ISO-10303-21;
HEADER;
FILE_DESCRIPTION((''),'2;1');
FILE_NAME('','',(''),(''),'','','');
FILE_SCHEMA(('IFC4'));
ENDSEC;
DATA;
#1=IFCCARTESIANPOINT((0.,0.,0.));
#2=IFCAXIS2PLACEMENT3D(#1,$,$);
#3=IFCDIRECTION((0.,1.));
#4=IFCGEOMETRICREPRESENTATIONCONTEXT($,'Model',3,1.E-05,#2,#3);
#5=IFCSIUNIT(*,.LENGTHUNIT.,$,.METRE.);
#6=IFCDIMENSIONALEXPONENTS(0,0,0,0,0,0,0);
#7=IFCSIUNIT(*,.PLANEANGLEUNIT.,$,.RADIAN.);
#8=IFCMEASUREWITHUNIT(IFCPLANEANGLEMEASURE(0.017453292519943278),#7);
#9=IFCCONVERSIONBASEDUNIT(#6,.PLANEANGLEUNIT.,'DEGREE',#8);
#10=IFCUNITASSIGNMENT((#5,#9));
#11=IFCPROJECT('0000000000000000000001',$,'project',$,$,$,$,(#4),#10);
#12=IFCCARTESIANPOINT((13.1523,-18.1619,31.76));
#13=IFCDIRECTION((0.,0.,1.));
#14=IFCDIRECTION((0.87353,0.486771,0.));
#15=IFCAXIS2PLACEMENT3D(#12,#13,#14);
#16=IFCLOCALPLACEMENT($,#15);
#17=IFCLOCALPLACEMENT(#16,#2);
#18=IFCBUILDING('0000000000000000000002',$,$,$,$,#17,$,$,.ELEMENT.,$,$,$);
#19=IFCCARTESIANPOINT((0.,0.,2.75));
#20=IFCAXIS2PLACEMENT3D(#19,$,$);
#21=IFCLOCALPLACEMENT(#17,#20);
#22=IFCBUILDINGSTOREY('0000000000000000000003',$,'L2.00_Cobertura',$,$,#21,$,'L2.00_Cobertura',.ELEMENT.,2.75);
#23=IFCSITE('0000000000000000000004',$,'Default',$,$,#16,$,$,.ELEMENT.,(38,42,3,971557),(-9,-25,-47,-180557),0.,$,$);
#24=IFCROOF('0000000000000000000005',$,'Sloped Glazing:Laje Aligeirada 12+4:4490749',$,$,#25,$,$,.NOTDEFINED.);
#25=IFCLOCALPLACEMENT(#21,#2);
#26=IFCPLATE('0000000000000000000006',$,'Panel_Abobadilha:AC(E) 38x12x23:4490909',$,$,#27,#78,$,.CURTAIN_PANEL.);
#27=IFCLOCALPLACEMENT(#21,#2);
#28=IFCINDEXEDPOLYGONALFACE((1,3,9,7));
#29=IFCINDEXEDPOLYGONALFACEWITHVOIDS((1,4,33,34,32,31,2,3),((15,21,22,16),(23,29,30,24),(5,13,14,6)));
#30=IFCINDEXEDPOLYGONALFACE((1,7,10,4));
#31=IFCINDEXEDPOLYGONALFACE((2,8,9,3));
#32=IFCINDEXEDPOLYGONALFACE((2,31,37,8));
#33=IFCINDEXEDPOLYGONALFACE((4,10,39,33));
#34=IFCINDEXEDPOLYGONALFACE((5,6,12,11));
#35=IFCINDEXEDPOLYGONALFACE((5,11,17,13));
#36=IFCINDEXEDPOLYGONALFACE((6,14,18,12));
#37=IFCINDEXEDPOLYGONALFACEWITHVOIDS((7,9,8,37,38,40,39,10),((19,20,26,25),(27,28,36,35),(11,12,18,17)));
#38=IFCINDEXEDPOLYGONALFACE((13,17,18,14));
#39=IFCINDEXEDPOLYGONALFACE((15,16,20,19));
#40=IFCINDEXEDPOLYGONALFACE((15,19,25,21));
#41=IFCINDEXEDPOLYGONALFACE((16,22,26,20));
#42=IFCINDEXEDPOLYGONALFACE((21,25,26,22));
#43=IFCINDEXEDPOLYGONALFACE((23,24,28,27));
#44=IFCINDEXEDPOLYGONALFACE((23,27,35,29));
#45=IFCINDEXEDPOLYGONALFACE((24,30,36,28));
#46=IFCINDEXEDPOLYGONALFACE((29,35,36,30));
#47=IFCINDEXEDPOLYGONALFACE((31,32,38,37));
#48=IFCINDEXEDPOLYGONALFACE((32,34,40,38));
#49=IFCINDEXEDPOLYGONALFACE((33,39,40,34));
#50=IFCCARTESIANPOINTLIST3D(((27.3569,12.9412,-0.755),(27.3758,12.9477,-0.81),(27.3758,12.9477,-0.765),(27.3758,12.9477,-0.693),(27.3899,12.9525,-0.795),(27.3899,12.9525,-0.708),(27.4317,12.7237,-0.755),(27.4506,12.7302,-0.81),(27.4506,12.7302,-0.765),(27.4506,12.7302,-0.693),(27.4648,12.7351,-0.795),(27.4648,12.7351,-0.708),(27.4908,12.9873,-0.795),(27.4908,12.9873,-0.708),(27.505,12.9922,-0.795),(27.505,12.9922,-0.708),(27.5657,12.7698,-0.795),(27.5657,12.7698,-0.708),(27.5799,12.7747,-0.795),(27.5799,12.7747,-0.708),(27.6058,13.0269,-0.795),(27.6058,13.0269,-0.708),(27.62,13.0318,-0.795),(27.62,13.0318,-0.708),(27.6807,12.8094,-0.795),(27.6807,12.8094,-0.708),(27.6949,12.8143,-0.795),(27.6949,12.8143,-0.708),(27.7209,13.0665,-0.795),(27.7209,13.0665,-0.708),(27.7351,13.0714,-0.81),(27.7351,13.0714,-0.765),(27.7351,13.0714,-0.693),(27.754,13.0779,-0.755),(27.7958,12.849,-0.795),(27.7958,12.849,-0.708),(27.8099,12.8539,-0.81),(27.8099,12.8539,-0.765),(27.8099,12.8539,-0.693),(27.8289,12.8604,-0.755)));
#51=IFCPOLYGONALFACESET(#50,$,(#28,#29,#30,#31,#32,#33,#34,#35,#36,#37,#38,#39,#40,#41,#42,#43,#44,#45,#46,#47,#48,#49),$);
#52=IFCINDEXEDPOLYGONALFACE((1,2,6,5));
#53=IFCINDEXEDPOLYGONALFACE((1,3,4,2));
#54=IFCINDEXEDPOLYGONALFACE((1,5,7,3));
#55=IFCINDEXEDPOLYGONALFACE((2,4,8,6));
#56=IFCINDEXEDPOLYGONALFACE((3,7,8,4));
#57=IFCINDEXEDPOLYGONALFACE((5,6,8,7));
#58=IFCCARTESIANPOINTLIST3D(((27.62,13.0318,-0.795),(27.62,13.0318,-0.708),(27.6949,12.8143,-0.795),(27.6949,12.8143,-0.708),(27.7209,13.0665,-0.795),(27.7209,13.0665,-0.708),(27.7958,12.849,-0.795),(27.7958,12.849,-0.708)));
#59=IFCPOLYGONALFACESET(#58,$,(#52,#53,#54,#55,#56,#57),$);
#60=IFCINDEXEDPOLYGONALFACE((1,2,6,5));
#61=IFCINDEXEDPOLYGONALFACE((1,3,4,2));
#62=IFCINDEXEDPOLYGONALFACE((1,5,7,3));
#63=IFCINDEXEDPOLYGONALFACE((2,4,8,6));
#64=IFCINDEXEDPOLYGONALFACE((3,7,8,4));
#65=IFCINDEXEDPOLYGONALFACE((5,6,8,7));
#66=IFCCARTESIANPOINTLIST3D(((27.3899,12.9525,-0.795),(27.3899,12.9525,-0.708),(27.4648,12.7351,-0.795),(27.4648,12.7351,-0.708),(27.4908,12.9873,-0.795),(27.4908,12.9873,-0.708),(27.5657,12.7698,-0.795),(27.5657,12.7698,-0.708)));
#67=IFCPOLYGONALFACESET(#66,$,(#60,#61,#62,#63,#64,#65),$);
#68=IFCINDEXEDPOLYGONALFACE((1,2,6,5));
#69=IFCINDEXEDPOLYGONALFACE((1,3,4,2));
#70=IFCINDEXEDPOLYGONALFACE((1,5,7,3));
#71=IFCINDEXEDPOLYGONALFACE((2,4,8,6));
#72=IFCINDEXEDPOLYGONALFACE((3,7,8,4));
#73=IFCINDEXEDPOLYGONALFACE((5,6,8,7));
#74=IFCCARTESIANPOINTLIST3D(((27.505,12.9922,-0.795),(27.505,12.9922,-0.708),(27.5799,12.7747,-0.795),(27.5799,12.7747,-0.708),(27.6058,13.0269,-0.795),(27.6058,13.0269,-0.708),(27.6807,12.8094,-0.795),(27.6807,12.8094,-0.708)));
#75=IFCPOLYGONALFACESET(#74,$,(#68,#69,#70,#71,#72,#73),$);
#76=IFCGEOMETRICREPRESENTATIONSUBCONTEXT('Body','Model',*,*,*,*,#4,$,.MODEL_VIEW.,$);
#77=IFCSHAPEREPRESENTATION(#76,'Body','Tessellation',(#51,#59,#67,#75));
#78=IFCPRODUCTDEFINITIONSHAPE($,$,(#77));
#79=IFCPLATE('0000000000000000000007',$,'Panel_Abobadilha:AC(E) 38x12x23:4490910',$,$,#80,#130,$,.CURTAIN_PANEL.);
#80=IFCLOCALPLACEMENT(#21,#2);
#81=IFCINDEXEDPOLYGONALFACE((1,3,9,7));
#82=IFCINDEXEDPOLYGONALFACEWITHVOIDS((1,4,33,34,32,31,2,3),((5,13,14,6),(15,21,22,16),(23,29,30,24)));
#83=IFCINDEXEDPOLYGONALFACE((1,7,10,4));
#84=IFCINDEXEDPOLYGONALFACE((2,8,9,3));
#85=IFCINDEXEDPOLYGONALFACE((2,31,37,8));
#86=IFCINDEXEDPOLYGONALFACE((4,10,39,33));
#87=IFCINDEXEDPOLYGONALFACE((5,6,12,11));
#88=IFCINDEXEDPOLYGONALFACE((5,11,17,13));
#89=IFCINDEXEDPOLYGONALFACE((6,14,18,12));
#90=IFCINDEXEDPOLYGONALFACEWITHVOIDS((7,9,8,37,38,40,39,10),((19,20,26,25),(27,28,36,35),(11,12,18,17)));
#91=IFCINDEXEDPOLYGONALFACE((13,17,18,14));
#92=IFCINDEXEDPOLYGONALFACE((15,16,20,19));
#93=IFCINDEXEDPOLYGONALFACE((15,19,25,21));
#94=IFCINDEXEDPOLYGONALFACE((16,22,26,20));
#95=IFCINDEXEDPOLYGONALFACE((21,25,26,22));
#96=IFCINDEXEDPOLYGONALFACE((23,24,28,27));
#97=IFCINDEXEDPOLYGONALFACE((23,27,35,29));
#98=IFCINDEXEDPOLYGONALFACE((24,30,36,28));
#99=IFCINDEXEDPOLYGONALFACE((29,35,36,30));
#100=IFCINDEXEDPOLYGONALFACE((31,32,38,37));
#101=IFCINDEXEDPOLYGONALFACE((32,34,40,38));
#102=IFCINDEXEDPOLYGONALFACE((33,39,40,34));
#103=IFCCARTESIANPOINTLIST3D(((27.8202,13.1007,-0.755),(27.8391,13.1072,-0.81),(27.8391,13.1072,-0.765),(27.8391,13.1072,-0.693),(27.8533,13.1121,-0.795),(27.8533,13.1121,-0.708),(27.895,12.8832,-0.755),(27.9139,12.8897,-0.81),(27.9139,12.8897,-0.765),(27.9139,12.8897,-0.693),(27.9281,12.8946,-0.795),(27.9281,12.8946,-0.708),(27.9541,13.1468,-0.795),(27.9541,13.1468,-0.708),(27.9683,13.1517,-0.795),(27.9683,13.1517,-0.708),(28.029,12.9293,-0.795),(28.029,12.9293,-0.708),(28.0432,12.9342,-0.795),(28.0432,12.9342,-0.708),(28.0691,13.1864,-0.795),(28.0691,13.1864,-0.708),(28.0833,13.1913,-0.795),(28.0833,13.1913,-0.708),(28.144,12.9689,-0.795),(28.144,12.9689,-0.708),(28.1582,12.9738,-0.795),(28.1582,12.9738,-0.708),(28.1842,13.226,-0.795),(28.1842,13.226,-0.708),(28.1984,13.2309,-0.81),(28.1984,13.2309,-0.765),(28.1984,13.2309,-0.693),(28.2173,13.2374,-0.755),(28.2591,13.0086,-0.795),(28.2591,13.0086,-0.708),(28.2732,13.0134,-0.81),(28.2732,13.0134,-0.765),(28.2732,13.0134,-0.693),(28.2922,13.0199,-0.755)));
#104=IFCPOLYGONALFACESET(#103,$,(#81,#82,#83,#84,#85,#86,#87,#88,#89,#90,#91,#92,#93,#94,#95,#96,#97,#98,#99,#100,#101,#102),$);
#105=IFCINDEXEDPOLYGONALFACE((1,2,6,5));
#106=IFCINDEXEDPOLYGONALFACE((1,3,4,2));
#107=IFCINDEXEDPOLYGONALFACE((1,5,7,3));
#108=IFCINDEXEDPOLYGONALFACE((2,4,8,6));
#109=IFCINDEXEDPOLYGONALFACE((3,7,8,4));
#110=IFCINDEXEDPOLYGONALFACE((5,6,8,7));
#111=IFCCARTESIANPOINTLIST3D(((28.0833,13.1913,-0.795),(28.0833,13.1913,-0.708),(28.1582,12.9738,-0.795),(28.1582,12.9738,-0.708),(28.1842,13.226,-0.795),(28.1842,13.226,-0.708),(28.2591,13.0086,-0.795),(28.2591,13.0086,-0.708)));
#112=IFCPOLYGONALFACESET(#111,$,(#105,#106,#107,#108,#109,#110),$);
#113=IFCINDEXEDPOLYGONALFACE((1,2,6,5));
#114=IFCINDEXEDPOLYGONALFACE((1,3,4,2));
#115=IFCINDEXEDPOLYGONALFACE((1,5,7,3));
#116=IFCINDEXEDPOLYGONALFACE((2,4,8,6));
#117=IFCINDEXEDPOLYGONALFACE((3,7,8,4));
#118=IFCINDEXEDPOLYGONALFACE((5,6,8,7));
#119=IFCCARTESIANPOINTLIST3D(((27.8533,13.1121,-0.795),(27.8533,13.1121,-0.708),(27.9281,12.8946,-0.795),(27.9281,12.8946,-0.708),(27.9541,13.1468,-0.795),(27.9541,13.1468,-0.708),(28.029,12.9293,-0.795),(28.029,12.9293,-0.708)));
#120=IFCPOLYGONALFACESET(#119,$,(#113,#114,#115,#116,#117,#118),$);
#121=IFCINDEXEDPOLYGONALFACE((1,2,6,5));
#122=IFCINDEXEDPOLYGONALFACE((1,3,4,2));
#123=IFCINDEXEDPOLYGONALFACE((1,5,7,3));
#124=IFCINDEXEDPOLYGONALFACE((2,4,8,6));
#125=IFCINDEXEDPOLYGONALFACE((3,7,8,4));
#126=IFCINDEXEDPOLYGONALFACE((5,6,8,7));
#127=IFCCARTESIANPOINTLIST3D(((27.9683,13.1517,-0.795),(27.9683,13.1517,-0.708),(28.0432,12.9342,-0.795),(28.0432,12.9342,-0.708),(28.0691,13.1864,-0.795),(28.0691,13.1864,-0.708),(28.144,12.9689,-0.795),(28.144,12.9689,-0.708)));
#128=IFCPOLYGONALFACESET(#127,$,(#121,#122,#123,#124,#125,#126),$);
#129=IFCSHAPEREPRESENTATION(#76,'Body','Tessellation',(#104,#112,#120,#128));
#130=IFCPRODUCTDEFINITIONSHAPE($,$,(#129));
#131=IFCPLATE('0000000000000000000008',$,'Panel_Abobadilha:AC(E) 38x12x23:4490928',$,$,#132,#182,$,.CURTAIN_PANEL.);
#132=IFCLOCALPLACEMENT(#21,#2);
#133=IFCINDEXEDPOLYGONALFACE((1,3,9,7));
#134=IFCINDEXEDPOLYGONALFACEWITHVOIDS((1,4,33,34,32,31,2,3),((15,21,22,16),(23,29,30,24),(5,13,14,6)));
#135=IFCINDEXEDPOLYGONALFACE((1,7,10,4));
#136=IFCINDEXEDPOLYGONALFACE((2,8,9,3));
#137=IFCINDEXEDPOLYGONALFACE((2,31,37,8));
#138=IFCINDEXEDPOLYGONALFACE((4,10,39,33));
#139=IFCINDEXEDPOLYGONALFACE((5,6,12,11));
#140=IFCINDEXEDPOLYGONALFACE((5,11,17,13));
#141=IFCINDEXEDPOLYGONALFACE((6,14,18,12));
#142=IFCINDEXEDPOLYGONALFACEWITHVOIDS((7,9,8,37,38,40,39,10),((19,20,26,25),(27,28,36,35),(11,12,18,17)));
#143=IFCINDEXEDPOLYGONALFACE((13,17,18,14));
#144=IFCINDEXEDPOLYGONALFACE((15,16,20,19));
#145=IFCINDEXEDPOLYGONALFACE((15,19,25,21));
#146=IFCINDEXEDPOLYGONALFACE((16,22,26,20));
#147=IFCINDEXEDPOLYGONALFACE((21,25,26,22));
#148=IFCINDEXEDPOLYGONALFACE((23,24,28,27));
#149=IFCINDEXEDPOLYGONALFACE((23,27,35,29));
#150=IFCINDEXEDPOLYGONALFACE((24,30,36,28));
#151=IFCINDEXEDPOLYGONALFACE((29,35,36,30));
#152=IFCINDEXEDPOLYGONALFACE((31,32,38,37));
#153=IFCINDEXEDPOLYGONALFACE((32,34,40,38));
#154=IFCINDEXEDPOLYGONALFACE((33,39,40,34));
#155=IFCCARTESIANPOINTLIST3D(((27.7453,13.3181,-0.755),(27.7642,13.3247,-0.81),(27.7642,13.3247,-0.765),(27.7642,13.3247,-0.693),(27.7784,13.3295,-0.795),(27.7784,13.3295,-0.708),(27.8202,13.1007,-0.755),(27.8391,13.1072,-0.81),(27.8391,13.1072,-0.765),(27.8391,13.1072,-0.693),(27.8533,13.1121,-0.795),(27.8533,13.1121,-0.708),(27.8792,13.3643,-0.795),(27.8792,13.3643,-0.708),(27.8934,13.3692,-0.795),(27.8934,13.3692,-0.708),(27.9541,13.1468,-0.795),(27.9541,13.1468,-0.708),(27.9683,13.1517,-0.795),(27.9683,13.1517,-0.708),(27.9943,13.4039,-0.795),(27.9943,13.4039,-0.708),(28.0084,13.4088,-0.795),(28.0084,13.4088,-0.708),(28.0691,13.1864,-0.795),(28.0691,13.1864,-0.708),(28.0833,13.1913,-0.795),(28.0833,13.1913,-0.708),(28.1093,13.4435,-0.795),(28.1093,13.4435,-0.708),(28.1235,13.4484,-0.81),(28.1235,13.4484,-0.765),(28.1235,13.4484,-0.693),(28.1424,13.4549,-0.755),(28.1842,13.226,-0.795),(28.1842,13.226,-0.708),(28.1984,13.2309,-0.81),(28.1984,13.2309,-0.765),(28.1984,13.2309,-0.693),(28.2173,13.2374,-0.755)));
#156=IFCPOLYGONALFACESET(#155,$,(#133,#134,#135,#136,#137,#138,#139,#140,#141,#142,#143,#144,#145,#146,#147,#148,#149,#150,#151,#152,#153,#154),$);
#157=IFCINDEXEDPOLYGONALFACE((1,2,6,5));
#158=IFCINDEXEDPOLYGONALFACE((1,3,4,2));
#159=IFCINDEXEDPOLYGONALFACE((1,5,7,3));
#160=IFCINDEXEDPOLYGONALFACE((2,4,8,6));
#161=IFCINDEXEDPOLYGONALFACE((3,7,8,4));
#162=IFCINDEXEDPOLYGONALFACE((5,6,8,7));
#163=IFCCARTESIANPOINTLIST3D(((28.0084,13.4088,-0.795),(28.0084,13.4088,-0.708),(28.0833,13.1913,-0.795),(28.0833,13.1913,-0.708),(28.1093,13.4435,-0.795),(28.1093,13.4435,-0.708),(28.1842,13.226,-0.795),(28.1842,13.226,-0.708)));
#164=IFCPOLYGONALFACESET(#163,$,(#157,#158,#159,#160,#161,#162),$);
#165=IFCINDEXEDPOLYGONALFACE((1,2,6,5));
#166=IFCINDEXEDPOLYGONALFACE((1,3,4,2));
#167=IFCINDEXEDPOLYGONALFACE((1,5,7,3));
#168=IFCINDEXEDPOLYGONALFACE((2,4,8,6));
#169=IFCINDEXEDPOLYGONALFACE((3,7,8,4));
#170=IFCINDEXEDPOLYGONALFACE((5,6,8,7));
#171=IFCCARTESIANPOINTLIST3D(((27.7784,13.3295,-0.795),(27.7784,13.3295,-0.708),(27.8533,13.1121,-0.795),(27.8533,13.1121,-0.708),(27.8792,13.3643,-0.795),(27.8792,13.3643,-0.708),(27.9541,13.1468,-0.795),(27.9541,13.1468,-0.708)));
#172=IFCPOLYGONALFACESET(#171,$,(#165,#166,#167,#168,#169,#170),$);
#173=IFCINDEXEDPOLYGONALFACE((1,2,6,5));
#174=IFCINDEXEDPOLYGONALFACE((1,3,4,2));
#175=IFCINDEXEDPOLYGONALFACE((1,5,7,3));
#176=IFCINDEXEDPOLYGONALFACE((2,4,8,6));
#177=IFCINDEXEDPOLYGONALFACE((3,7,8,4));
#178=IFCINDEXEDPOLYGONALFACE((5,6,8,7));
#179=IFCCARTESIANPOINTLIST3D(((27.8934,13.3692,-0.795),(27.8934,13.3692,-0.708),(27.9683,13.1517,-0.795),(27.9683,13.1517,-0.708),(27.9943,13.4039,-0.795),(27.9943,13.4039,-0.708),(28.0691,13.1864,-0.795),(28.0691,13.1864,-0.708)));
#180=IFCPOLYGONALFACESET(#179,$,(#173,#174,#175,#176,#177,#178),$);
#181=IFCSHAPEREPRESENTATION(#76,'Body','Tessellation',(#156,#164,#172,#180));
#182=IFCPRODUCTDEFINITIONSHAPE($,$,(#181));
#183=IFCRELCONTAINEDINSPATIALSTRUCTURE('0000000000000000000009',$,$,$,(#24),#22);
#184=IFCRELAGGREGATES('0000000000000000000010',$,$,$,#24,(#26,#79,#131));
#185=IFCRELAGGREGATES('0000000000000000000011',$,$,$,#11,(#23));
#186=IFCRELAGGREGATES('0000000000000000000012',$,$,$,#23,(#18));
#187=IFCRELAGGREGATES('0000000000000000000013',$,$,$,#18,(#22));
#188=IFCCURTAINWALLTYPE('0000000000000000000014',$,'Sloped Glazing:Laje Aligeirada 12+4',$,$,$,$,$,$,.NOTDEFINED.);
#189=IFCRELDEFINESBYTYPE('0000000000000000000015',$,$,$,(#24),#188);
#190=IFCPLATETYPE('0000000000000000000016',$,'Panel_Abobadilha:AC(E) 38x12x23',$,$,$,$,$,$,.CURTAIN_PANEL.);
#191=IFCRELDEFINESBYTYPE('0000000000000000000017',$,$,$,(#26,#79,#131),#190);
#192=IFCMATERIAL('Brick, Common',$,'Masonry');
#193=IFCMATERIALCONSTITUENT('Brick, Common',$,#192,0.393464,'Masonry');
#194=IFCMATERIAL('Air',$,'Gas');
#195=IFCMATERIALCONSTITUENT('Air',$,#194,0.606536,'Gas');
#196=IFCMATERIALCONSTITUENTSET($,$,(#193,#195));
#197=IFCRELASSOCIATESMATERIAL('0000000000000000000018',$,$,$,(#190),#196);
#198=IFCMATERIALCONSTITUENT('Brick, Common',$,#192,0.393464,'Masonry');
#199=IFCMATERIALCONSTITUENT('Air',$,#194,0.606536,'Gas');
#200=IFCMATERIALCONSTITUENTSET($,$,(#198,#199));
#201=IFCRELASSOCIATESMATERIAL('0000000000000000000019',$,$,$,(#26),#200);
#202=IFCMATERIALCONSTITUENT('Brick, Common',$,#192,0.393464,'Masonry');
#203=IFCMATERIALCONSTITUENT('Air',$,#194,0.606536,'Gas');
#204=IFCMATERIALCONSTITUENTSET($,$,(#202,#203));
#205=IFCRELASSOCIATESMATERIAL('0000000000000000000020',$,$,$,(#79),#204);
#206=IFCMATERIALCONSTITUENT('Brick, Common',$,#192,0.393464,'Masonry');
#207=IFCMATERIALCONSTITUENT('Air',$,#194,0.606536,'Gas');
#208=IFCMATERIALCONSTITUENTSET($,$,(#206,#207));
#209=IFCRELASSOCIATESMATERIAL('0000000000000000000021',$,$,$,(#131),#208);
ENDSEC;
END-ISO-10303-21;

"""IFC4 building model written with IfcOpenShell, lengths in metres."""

from ifc_helpers import new_model, entity, si_unit, converted_unit, direction, frame, origin, place, context, subcontext, project, spatial, indexed_curve, outline, extrude, source, transform, mapped, material, constituent, constituent_set, type_object, type_shapes, element, aggregate, save


model = new_model("IFC4")

# Units and contexts
model_context = context("Model", 3, precision=1e-05, world=origin(), true_north=direction((0.0, 1.0)))
body_context = subcontext(model_context, "Body", "Model", "MODEL_VIEW")
ifc_project = project(units=[si_unit("LENGTHUNIT", "METRE"), converted_unit("PLANEANGLEUNIT", "DEGREE", entity("IfcPlaneAngleMeasure", 0.017453292519943278), si_unit("PLANEANGLEUNIT", "RADIAN"), dimensions=[0, 0, 0, 0, 0, 0, 0])], contexts=[model_context])

# Site, building, storey
site_placement = place(None, frame((13.1523, -18.1619, 31.76), z_axis=(0.0, 0.0, 1.0), x_axis=(0.87353, 0.486771, 0.0)))
site = spatial("IfcSite", under=ifc_project, at=site_placement, Name="Default", CompositionType="ELEMENT", RefLatitude=(38, 42, 3, 971557), RefLongitude=(-9, -25, -47, -180557), RefElevation=0.0)
building_placement = place(site_placement, origin())
building = spatial("IfcBuilding", under=site, at=building_placement, CompositionType="ELEMENT")
storey_placement = place(building_placement, frame((0.0, 0.0, 2.75)))
storey = spatial("IfcBuildingStorey", under=building, at=storey_placement, Name="L2.00_Cobertura", LongName="L2.00_Cobertura", CompositionType="ELEMENT", Elevation=2.75)

# Roof, plates
curtain_wall_type = type_object("IfcCurtainWallType", Name="Sloped Glazing:Laje Aligeirada 12+4", PredefinedType="NOTDEFINED")
roof_placement = place(storey_placement, frame((0.0, 0.0, -2.75)))
roof = element("IfcRoof", 1, at=roof_placement, inside=storey, type_object=curtain_wall_type, Name="Sloped Glazing:Laje Aligeirada 12+4:4490749", PredefinedType="NOTDEFINED")
ifc_material_1 = material(Name="Brick, Common", Category="Masonry")
ifc_material_2 = material(Name="Air", Category="Gas")
ifc_constituent_1 = constituent(ifc_material_1, Name="Brick, Common", Category="Masonry", fraction=0.393464)
ifc_constituent_2 = constituent(ifc_material_2, Name="Air", Category="Gas", fraction=0.606536)
ifc_constituent_set_1 = constituent_set(constituents=[ifc_constituent_1, ifc_constituent_2])
plate_type_1 = type_object("IfcPlateType", Name="Panel_Abobadilha:AC(E) 38x12x23", PredefinedType="CURTAIN_PANEL", material=ifc_constituent_set_1)
shared_shape_1 = source(origin(), body_context, "Body", "SweptSolid", [
    extrude(outline(indexed_curve([(-0.19, -0.0543), (0.19, -0.0543), (0.19, -0.0093), (0.21, 0.0007), (0.19, 0.0628), (-0.19, 0.0628), (-0.21, 0.0007), (-0.19, -0.0093), (-0.19, -0.0543)], self_intersect=False), holes=[indexed_curve([(-0.0683, 0.0477), (-0.0683, -0.0393), (-0.175, -0.0393), (-0.175, 0.0477), (-0.0683, 0.0477)], self_intersect=False), indexed_curve([(0.0533, 0.0477), (0.0533, -0.0393), (-0.0533, -0.0393), (-0.0533, 0.0477), (0.0533, 0.0477)], self_intersect=False), indexed_curve([(0.175, 0.0477), (0.175, -0.0393), (0.0683, -0.0393), (0.0683, 0.0477), (0.175, 0.0477)], self_intersect=False)]), frame((0.0, 0.0543, 0.0)), (0.0, 0.0, 1.0), 0.23),
    extrude(outline(indexed_curve([(-0.0533, -0.0435), (0.0533, -0.0435), (0.0533, 0.0435), (-0.0533, 0.0435), (-0.0533, -0.0435)], self_intersect=False)), frame((0.1217, 0.0585, 0.0), z_axis=(0.0, 0.0, 1.0), x_axis=(-1.0, 0.0, 0.0)), (0.0, 0.0, 1.0), 0.23),
    extrude(outline(indexed_curve([(-0.0533, -0.0435), (0.0533, -0.0435), (0.0533, 0.0435), (-0.0533, 0.0435), (-0.0533, -0.0435)], self_intersect=False)), frame((-0.1217, 0.0585, 0.0), z_axis=(0.0, 0.0, 1.0), x_axis=(-1.0, 0.0, 0.0)), (0.0, 0.0, 1.0), 0.23),
    extrude(outline(indexed_curve([(-0.0533, -0.0435), (0.0533, -0.0435), (0.0533, 0.0435), (-0.0533, 0.0435), (-0.0533, -0.0435)], self_intersect=False)), frame((0.0, 0.0585, 0.0), z_axis=(0.0, 0.0, 1.0), x_axis=(-1.0, 0.0, 0.0)), (0.0, 0.0, 1.0), 0.23),
])
type_shapes(plate_type_1, [shared_shape_1])
ifc_constituent_3 = constituent(ifc_material_1, Name="Brick, Common", Category="Masonry", fraction=0.393464)
ifc_constituent_4 = constituent(ifc_material_2, Name="Air", Category="Gas", fraction=0.606536)
ifc_constituent_set_2 = constituent_set(constituents=[ifc_constituent_3, ifc_constituent_4])
plate_1_placement = place(roof_placement, frame((27.5554, 13.0095, 1.94), z_axis=(0.325568, -0.945519, 0.0), x_axis=(0.945519, 0.325568, 0.0)))
plate_1 = element("IfcPlate", 2, at=plate_1_placement, type_object=plate_type_1, material=ifc_constituent_set_2, Name="Panel_Abobadilha:AC(E) 38x12x23:4490909", PredefinedType="CURTAIN_PANEL", context=body_context, shape_type="MappedRepresentation", body=[
    mapped(shared_shape_1, transform((0.0, 0.0, 0.0), scale=1.0)),
])
ifc_constituent_5 = constituent(ifc_material_1, Name="Brick, Common", Category="Masonry", fraction=0.393464)
ifc_constituent_6 = constituent(ifc_material_2, Name="Air", Category="Gas", fraction=0.606536)
ifc_constituent_set_3 = constituent_set(constituents=[ifc_constituent_5, ifc_constituent_6])
plate_2_placement = place(roof_placement, frame((28.0187, 13.169, 1.94), z_axis=(0.325568, -0.945519, 0.0), x_axis=(0.945519, 0.325568, 0.0)))
plate_2 = element("IfcPlate", 3, at=plate_2_placement, type_object=plate_type_1, material=ifc_constituent_set_3, Name="Panel_Abobadilha:AC(E) 38x12x23:4490910", PredefinedType="CURTAIN_PANEL", context=body_context, shape_type="MappedRepresentation", body=[
    mapped(shared_shape_1, transform((0.0, 0.0, 0.0), scale=1.0)),
])
ifc_constituent_7 = constituent(ifc_material_1, Name="Brick, Common", Category="Masonry", fraction=0.393464)
ifc_constituent_8 = constituent(ifc_material_2, Name="Air", Category="Gas", fraction=0.606536)
ifc_constituent_set_4 = constituent_set(constituents=[ifc_constituent_7, ifc_constituent_8])
plate_3_placement = place(roof_placement, frame((27.9438, 13.3865, 1.94), z_axis=(0.325568, -0.945519, 0.0), x_axis=(0.945519, 0.325568, 0.0)))
plate_3 = element("IfcPlate", 4, at=plate_3_placement, type_object=plate_type_1, material=ifc_constituent_set_4, Name="Panel_Abobadilha:AC(E) 38x12x23:4490928", PredefinedType="CURTAIN_PANEL", context=body_context, shape_type="MappedRepresentation", body=[
    mapped(shared_shape_1, transform((0.0, 0.0, 0.0), scale=1.0)),
])
aggregate(roof, [plate_1, plate_2, plate_3])

save(model, "model.ifc")
